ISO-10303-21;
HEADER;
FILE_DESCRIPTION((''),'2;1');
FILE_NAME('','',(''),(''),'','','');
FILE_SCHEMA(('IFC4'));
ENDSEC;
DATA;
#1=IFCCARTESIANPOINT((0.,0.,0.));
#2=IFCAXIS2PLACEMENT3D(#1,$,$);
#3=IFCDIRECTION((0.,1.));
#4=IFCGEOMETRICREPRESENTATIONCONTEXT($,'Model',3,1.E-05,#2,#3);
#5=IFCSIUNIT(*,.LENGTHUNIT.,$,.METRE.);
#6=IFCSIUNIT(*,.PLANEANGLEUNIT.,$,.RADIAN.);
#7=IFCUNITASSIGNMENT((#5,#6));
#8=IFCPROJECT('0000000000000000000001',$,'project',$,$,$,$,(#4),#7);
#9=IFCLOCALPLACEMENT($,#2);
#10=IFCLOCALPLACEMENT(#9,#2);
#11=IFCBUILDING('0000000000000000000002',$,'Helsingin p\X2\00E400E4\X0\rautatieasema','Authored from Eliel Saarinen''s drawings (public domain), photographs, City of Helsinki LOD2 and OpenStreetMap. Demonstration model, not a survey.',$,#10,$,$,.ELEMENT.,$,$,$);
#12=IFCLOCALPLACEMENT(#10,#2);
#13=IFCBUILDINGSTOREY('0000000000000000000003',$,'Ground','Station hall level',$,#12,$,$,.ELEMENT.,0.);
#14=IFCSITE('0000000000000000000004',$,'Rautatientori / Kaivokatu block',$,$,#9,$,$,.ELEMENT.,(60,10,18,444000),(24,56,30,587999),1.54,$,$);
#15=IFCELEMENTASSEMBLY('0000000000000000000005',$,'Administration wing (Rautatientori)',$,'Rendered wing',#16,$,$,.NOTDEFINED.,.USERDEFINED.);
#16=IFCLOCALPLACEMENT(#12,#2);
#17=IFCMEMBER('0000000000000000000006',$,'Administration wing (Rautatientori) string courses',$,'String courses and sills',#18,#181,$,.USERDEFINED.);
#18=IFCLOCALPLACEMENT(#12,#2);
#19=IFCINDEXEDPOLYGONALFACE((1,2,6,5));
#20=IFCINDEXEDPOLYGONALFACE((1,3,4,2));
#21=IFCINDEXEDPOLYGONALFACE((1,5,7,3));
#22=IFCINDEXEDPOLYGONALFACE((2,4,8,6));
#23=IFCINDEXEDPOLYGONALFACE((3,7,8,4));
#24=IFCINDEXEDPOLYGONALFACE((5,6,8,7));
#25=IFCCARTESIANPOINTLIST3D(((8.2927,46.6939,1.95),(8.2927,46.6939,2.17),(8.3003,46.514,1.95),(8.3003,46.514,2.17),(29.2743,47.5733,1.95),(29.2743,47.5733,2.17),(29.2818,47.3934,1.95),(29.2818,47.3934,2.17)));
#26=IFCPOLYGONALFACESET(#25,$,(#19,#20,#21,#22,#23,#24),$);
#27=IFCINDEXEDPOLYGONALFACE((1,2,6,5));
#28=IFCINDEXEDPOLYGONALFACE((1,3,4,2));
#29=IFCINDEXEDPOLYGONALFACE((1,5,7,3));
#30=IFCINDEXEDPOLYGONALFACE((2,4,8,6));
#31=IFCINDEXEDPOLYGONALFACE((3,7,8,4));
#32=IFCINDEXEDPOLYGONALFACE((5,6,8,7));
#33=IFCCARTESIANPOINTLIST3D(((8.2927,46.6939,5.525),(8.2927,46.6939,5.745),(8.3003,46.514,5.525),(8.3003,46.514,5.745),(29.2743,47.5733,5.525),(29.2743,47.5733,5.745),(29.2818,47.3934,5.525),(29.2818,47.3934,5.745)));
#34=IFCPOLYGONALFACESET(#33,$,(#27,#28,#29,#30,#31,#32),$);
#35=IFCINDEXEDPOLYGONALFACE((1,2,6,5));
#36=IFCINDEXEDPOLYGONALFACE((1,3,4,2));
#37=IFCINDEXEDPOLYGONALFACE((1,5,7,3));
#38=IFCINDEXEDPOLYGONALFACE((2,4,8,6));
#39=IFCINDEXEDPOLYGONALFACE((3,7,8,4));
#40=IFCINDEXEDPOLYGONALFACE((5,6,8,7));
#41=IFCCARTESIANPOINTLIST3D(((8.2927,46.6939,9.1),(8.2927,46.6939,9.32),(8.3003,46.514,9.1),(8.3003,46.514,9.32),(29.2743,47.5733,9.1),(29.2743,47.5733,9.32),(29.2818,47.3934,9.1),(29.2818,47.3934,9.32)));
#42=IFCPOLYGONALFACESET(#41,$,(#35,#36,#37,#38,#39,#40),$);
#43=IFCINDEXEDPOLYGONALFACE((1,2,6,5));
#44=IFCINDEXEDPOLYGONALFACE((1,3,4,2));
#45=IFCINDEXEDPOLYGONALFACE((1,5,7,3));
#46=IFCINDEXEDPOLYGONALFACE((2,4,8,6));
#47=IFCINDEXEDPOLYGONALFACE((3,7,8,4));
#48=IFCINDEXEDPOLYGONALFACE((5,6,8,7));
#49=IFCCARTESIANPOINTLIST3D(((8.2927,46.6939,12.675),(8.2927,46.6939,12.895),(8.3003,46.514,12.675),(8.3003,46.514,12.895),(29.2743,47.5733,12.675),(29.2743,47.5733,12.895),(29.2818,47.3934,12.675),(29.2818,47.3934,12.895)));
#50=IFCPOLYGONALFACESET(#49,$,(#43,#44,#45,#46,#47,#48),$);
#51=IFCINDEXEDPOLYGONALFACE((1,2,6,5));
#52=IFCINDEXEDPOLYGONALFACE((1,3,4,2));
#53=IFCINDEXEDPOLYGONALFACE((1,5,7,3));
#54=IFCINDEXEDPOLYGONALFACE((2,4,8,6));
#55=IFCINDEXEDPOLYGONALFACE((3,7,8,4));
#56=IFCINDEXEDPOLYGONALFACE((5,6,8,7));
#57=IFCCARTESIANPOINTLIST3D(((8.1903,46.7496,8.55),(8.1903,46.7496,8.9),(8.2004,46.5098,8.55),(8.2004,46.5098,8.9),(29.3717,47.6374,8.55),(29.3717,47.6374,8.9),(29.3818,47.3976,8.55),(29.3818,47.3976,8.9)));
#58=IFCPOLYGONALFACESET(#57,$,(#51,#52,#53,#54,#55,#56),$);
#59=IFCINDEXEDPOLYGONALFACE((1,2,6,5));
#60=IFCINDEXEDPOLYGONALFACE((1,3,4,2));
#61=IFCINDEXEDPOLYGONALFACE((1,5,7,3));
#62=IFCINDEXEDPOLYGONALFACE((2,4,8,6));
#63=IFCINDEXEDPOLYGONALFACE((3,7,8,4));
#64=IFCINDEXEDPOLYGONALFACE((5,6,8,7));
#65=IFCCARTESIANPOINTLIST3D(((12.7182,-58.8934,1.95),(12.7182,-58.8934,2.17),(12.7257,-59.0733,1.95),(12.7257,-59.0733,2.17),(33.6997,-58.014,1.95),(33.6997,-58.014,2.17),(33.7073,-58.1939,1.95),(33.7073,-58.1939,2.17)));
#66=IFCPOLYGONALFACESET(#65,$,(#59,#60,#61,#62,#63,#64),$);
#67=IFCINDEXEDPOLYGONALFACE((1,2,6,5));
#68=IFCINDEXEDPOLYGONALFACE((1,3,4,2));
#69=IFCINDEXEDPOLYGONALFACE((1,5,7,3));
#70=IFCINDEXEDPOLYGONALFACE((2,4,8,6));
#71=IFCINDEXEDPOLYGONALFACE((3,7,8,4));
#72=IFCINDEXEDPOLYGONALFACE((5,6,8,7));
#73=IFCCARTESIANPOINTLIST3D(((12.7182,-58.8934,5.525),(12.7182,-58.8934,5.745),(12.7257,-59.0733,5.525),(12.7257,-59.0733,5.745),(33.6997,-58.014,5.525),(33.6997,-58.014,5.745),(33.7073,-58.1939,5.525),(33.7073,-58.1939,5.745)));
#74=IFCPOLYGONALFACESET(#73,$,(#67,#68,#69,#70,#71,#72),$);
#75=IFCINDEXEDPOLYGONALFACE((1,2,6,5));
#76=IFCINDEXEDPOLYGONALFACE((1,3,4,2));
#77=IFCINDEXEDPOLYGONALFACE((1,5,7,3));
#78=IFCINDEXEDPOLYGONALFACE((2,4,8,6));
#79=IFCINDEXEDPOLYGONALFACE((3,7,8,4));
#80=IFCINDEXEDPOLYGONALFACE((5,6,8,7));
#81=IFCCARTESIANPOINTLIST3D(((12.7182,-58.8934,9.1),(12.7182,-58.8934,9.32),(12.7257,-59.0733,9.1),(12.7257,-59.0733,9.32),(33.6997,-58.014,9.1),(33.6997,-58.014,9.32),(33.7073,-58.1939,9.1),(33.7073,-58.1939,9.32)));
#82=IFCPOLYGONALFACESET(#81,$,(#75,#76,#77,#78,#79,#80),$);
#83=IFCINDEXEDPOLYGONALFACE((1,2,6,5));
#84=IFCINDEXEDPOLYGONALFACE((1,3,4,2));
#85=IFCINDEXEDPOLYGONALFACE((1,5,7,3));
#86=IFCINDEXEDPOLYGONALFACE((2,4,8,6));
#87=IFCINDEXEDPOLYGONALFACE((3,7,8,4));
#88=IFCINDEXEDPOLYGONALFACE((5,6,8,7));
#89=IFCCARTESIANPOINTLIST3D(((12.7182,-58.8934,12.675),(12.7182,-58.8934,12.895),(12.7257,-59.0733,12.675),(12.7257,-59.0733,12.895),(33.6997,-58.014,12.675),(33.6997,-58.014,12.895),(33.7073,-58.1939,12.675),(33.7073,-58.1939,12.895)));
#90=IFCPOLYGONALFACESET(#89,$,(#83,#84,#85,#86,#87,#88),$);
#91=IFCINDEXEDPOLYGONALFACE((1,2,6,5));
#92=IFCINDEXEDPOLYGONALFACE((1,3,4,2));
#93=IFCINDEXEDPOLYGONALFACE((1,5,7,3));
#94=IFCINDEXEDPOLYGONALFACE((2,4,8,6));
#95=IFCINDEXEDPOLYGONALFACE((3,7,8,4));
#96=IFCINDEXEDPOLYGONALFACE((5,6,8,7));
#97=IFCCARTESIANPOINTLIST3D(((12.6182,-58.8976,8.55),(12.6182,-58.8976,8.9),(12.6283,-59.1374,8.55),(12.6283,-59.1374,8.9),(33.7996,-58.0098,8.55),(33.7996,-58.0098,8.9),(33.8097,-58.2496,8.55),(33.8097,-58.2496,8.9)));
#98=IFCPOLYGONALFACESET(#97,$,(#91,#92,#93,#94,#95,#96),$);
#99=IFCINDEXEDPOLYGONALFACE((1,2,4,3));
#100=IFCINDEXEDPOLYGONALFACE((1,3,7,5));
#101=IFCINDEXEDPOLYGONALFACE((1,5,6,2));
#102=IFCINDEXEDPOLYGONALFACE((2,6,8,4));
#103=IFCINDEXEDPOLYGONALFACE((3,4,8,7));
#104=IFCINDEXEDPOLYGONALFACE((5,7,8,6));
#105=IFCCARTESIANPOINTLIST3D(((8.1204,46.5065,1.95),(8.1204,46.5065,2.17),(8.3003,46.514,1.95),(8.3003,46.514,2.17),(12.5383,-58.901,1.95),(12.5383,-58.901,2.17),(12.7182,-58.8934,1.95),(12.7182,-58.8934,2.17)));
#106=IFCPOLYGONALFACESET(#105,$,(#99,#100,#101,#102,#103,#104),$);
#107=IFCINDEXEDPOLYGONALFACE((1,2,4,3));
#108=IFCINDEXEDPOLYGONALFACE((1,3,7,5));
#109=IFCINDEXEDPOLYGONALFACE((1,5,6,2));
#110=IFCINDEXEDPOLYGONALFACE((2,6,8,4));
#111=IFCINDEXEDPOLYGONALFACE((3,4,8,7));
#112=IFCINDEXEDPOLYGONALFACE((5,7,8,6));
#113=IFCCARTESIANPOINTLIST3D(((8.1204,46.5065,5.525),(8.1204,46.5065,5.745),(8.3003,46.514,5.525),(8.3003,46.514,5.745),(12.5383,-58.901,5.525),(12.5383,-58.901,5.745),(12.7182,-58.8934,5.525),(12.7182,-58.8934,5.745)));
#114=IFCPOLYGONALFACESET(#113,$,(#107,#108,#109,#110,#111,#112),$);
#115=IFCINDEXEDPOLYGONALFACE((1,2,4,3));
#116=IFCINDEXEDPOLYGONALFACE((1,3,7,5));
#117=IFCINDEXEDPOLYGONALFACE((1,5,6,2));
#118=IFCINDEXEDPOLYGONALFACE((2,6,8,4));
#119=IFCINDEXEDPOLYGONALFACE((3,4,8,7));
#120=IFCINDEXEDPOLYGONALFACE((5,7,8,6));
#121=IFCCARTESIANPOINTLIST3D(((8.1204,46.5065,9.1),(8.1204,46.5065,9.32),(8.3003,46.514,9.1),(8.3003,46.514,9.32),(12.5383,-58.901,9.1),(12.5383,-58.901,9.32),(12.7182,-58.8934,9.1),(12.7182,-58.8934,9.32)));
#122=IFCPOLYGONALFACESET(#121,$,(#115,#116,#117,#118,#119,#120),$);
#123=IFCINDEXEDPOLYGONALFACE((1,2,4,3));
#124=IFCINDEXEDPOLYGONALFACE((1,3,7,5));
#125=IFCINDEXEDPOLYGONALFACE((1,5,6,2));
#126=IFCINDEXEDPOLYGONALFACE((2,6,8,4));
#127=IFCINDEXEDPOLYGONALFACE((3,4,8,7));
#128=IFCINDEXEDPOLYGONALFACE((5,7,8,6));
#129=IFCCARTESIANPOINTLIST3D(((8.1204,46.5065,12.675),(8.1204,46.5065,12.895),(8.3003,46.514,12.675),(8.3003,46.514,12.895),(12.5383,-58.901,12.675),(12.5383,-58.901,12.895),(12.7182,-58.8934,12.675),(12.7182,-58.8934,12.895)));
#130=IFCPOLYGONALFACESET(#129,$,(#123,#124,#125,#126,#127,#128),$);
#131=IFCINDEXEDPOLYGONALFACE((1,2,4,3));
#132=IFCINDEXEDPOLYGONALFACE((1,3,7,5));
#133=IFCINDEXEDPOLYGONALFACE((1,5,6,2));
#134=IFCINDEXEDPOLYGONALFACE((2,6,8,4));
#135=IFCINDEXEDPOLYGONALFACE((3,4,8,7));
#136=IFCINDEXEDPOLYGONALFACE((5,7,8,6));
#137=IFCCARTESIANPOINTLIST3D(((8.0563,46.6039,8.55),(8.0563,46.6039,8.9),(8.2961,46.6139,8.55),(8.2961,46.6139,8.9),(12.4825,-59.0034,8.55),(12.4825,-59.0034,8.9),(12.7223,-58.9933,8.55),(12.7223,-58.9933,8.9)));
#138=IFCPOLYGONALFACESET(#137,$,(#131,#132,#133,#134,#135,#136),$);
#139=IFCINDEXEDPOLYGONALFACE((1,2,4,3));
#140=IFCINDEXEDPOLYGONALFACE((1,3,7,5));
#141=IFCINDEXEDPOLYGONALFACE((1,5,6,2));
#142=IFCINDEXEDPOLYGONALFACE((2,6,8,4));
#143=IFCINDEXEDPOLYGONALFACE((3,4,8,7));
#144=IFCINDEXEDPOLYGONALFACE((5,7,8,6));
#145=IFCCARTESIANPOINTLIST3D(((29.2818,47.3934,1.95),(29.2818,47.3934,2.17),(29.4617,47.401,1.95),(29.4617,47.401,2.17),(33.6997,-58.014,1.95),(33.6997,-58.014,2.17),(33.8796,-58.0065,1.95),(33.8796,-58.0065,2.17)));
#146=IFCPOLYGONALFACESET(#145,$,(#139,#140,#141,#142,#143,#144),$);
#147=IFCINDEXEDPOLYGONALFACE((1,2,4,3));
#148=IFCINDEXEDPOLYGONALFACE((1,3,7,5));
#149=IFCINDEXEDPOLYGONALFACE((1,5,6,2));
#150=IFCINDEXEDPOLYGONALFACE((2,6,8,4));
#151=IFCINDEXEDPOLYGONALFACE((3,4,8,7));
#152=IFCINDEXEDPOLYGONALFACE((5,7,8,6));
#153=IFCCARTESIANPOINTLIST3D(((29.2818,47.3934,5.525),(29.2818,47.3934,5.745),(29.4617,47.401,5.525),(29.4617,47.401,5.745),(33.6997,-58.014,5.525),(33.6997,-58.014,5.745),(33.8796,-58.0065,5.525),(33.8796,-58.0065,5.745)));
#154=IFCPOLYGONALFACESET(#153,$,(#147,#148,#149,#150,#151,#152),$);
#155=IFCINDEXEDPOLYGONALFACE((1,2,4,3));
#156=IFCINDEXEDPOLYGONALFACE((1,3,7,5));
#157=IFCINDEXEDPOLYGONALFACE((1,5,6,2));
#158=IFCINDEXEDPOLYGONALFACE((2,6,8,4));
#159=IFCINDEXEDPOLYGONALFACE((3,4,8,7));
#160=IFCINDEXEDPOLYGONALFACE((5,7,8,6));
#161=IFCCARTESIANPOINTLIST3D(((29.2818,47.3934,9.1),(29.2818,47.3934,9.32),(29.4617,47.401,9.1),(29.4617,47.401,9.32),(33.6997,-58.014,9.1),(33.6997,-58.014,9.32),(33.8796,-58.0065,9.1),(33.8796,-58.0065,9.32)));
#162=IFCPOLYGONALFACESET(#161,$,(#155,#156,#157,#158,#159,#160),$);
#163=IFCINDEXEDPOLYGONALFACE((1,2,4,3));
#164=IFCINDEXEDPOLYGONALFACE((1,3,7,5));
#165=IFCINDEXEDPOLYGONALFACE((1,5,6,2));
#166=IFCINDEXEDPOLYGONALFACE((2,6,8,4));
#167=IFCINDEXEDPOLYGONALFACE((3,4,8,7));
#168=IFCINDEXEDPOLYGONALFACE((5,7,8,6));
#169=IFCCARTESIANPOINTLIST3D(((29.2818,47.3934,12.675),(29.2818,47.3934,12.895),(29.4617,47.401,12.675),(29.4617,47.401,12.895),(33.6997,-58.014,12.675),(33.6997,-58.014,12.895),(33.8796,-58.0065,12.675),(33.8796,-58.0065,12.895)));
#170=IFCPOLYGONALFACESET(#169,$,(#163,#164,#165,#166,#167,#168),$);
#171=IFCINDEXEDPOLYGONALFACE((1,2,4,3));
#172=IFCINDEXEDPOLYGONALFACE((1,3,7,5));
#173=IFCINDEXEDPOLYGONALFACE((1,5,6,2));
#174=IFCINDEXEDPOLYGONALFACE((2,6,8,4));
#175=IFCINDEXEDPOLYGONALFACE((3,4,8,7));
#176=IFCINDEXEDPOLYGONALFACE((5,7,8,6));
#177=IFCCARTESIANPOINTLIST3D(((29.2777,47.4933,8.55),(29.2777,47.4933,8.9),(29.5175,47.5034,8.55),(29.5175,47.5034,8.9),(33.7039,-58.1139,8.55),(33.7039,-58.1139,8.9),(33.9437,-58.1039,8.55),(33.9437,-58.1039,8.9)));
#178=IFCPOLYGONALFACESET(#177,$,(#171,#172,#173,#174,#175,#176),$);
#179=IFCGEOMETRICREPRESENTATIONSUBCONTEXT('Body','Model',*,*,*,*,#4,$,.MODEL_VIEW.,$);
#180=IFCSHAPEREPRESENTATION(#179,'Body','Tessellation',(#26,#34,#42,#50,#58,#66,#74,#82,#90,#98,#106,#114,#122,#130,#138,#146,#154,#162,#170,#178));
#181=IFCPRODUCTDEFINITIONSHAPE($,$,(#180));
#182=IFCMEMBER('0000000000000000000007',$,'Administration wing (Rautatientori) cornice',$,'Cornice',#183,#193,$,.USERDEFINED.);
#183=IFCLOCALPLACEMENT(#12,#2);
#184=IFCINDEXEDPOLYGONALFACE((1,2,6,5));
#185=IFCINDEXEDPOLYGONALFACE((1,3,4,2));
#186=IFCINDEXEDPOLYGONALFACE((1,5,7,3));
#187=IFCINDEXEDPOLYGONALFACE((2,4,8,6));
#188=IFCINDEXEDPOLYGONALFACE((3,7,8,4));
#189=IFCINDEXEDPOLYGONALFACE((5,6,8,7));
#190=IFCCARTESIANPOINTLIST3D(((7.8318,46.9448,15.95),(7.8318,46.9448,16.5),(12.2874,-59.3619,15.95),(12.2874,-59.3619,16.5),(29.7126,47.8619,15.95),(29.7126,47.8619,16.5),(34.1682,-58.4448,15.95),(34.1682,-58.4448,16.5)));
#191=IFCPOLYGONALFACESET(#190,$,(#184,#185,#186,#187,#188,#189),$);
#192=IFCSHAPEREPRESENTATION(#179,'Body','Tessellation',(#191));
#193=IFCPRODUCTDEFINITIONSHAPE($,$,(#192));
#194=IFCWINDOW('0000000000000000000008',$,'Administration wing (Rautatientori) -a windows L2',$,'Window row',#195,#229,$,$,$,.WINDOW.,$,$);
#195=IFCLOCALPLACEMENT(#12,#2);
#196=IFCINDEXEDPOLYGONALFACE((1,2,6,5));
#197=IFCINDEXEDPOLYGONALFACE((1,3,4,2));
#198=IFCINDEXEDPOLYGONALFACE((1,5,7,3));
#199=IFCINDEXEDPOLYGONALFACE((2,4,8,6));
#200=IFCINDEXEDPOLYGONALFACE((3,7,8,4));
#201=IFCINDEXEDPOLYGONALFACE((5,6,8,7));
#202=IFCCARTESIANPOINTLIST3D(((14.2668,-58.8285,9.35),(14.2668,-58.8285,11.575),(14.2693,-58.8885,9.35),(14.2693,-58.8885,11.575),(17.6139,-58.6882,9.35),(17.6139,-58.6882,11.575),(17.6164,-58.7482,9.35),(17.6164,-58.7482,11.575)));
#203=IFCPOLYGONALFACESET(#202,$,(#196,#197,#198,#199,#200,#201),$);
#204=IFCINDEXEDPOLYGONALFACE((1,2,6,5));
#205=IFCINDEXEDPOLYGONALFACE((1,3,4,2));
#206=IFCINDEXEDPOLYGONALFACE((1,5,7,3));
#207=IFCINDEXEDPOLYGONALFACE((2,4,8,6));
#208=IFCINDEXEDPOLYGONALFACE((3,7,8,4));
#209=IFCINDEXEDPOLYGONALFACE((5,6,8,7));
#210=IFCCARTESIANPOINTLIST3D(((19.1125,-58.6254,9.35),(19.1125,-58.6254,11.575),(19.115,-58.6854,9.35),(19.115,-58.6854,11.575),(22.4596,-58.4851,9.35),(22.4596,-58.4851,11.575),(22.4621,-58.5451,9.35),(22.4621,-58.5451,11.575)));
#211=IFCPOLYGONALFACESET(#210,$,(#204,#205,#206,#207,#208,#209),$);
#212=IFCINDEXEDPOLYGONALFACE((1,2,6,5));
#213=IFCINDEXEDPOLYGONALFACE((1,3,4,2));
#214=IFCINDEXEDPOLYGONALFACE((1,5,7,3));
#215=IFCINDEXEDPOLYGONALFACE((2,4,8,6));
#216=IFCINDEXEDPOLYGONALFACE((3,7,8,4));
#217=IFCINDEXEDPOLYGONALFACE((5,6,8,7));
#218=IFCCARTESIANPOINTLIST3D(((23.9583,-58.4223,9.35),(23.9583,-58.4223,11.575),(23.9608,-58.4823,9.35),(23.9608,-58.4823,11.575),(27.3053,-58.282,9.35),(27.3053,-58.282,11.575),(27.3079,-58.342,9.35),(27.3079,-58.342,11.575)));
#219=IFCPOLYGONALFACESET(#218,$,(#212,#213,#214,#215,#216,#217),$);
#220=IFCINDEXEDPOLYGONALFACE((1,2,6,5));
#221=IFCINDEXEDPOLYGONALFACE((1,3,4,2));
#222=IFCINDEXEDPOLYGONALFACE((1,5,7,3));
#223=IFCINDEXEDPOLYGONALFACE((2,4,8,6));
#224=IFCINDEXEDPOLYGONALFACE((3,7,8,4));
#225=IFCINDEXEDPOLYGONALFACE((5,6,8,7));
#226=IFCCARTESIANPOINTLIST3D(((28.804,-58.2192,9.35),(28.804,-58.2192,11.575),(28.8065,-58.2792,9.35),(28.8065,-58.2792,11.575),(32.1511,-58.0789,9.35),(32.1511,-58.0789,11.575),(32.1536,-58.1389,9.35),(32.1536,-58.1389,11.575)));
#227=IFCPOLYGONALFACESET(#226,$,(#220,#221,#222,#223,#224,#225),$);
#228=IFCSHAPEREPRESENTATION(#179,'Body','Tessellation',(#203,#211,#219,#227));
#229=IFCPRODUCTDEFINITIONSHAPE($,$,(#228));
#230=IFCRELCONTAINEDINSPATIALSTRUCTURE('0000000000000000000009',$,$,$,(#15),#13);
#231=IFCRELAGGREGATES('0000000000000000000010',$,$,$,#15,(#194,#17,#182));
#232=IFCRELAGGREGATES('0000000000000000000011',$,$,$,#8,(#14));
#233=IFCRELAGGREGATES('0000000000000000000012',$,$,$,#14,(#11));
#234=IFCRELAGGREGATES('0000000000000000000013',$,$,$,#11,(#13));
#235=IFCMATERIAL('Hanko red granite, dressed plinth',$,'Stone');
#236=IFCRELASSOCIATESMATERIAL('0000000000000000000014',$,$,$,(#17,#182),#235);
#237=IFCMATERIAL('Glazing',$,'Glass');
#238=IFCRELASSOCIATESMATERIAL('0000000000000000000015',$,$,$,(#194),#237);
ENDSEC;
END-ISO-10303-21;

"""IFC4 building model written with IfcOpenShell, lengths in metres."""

from ifc_helpers import new_model, si_unit, direction, frame, frame_2d, origin, place, context, subcontext, project, spatial, rectangle, extrude, material, element, aggregate, save


model = new_model("IFC4")

# Units and contexts
model_context = context("Model", 3, precision=1e-05, world=origin(), true_north=direction((0.0, 1.0)))
body_context = subcontext(model_context, "Body", "Model", "MODEL_VIEW")
ifc_project = project(units=[si_unit("LENGTHUNIT", "METRE"), si_unit("PLANEANGLEUNIT", "RADIAN")], contexts=[model_context])

# Site, building, storey
site_placement = place(None, origin())
site = spatial("IfcSite", under=ifc_project, at=site_placement, Name="Rautatientori / Kaivokatu block", CompositionType="ELEMENT", RefLatitude=(60, 10, 18, 444000), RefLongitude=(24, 56, 30, 587999), RefElevation=1.54)
building_placement = place(site_placement, origin())
building = spatial("IfcBuilding", under=site, at=building_placement, Name="Helsingin päärautatieasema", Description="Authored from Eliel Saarinen's drawings (public domain), photographs, City of Helsinki LOD2 and OpenStreetMap. Demonstration model, not a survey.", CompositionType="ELEMENT")
storey_placement = place(building_placement, origin())
storey = spatial("IfcBuildingStorey", under=building, at=storey_placement, Name="Ground", Description="Station hall level", CompositionType="ELEMENT", Elevation=0.0)

# Element assembly, members, window
assembly_placement = place(building_placement, origin())
assembly = element("IfcElementAssembly", 1, at=assembly_placement, inside=storey, Name="Administration wing (Rautatientori)", ObjectType="Rendered wing", AssemblyPlace="NOTDEFINED", PredefinedType="USERDEFINED")
ifc_material_1 = material(Name="Hanko red granite, dressed plinth", Category="Stone")
member_1_placement = place(building_placement, origin())
member_1 = element("IfcMember", 2, at=member_1_placement, material=ifc_material_1, Name="Administration wing (Rautatientori) string courses", ObjectType="String courses and sills", PredefinedType="USERDEFINED", context=body_context, shape_type="SweptSolid", body=[
    extrude(rectangle(XDim=21.0, YDim=0.18, at=frame_2d((0.0, 0.0), x_axis=(-0.999123, -0.041876))), frame((18.7873, 47.0437, 1.95)), (0.0, 0.0, 1.0), 0.22),
    extrude(rectangle(XDim=21.0, YDim=0.18, at=frame_2d((0.0, 0.0), x_axis=(-0.999123, -0.041876))), frame((18.7873, 47.0437, 5.525)), (0.0, 0.0, 1.0), 0.22),
    extrude(rectangle(XDim=21.0, YDim=0.18, at=frame_2d((0.0, 0.0), x_axis=(-0.999123, -0.041876))), frame((18.7873, 47.0437, 9.1)), (0.0, 0.0, 1.0), 0.22),
    extrude(rectangle(XDim=21.0, YDim=0.18, at=frame_2d((0.0, 0.0), x_axis=(-0.999123, -0.041876))), frame((18.7873, 47.0437, 12.675)), (0.0, 0.0, 1.0), 0.22),
    extrude(rectangle(XDim=21.2, YDim=0.24, at=frame_2d((0.0, 0.0), x_axis=(-0.999123, -0.041876))), frame((18.786, 47.0736, 8.55)), (0.0, 0.0, 1.0), 0.35),
    extrude(rectangle(XDim=21.0, YDim=0.18, at=frame_2d((0.0, 0.0), x_axis=(0.999123, 0.041876))), frame((23.2127, -58.5437, 1.95)), (0.0, 0.0, 1.0), 0.22),
    extrude(rectangle(XDim=21.0, YDim=0.18, at=frame_2d((0.0, 0.0), x_axis=(0.999123, 0.041876))), frame((23.2127, -58.5437, 5.525)), (0.0, 0.0, 1.0), 0.22),
    extrude(rectangle(XDim=21.0, YDim=0.18, at=frame_2d((0.0, 0.0), x_axis=(0.999123, 0.041876))), frame((23.2127, -58.5437, 9.1)), (0.0, 0.0, 1.0), 0.22),
    extrude(rectangle(XDim=21.0, YDim=0.18, at=frame_2d((0.0, 0.0), x_axis=(0.999123, 0.041876))), frame((23.2127, -58.5437, 12.675)), (0.0, 0.0, 1.0), 0.22),
    extrude(rectangle(XDim=21.2, YDim=0.24, at=frame_2d((0.0, 0.0), x_axis=(0.999123, 0.041876))), frame((23.214, -58.5736, 8.55)), (0.0, 0.0, 1.0), 0.35),
    extrude(rectangle(XDim=105.5, YDim=0.18, at=frame_2d((0.0, 0.0), x_axis=(0.041876, -0.999123))), frame((10.4193, -6.1935, 1.95)), (0.0, 0.0, 1.0), 0.22),
    extrude(rectangle(XDim=105.5, YDim=0.18, at=frame_2d((0.0, 0.0), x_axis=(0.041876, -0.999123))), frame((10.4193, -6.1935, 5.525)), (0.0, 0.0, 1.0), 0.22),
    extrude(rectangle(XDim=105.5, YDim=0.18, at=frame_2d((0.0, 0.0), x_axis=(0.041876, -0.999123))), frame((10.4193, -6.1935, 9.1)), (0.0, 0.0, 1.0), 0.22),
    extrude(rectangle(XDim=105.5, YDim=0.18, at=frame_2d((0.0, 0.0), x_axis=(0.041876, -0.999123))), frame((10.4193, -6.1935, 12.675)), (0.0, 0.0, 1.0), 0.22),
    extrude(rectangle(XDim=105.7, YDim=0.24, at=frame_2d((0.0, 0.0), x_axis=(0.041876, -0.999123))), frame((10.3893, -6.1947, 8.55)), (0.0, 0.0, 1.0), 0.35),
    extrude(rectangle(XDim=105.5, YDim=0.18, at=frame_2d((0.0, 0.0), x_axis=(-0.041876, 0.999123))), frame((31.5807, -5.3065, 1.95)), (0.0, 0.0, 1.0), 0.22),
    extrude(rectangle(XDim=105.5, YDim=0.18, at=frame_2d((0.0, 0.0), x_axis=(-0.041876, 0.999123))), frame((31.5807, -5.3065, 5.525)), (0.0, 0.0, 1.0), 0.22),
    extrude(rectangle(XDim=105.5, YDim=0.18, at=frame_2d((0.0, 0.0), x_axis=(-0.041876, 0.999123))), frame((31.5807, -5.3065, 9.1)), (0.0, 0.0, 1.0), 0.22),
    extrude(rectangle(XDim=105.5, YDim=0.18, at=frame_2d((0.0, 0.0), x_axis=(-0.041876, 0.999123))), frame((31.5807, -5.3065, 12.675)), (0.0, 0.0, 1.0), 0.22),
    extrude(rectangle(XDim=105.7, YDim=0.24, at=frame_2d((0.0, 0.0), x_axis=(-0.041876, 0.999123))), frame((31.6107, -5.3053, 8.55)), (0.0, 0.0, 1.0), 0.35),
])
member_2_placement = place(building_placement, origin())
member_2 = element("IfcMember", 3, at=member_2_placement, material=ifc_material_1, Name="Administration wing (Rautatientori) cornice", ObjectType="Cornice", PredefinedType="USERDEFINED", context=body_context, shape_type="SweptSolid", body=[
    extrude(rectangle(XDim=106.4, YDim=21.9, at=frame_2d((0.0, 0.0), x_axis=(-0.041876, 0.999123))), frame((21.0, -5.75, 15.95)), (0.0, 0.0, 1.0), 0.55),
])
ifc_material_2 = material(Name="Glazing", Category="Glass")
window_1_placement = place(building_placement, origin())
window_1 = element("IfcWindow", 4, at=window_1_placement, material=ifc_material_2, Name="Administration wing (Rautatientori) -a windows L2", ObjectType="Window row", PredefinedType="WINDOW", context=body_context, shape_type="SweptSolid", body=[
    extrude(rectangle(XDim=3.35, YDim=0.06, at=frame_2d((0.0, 0.0), x_axis=(0.999123, 0.041876))), frame((15.9416, -58.7883, 9.35)), (0.0, 0.0, 1.0), 2.225),
    extrude(rectangle(XDim=3.35, YDim=0.06, at=frame_2d((0.0, 0.0), x_axis=(0.999123, 0.041876))), frame((20.7873, -58.5853, 9.35)), (0.0, 0.0, 1.0), 2.225),
    extrude(rectangle(XDim=3.35, YDim=0.06, at=frame_2d((0.0, 0.0), x_axis=(0.999123, 0.041876))), frame((25.6331, -58.3822, 9.35)), (0.0, 0.0, 1.0), 2.225),
    extrude(rectangle(XDim=3.35, YDim=0.06, at=frame_2d((0.0, 0.0), x_axis=(0.999123, 0.041876))), frame((30.4788, -58.1791, 9.35)), (0.0, 0.0, 1.0), 2.225),
])
aggregate(assembly, [window_1, member_1, member_2])

save(model, "model.ifc")
